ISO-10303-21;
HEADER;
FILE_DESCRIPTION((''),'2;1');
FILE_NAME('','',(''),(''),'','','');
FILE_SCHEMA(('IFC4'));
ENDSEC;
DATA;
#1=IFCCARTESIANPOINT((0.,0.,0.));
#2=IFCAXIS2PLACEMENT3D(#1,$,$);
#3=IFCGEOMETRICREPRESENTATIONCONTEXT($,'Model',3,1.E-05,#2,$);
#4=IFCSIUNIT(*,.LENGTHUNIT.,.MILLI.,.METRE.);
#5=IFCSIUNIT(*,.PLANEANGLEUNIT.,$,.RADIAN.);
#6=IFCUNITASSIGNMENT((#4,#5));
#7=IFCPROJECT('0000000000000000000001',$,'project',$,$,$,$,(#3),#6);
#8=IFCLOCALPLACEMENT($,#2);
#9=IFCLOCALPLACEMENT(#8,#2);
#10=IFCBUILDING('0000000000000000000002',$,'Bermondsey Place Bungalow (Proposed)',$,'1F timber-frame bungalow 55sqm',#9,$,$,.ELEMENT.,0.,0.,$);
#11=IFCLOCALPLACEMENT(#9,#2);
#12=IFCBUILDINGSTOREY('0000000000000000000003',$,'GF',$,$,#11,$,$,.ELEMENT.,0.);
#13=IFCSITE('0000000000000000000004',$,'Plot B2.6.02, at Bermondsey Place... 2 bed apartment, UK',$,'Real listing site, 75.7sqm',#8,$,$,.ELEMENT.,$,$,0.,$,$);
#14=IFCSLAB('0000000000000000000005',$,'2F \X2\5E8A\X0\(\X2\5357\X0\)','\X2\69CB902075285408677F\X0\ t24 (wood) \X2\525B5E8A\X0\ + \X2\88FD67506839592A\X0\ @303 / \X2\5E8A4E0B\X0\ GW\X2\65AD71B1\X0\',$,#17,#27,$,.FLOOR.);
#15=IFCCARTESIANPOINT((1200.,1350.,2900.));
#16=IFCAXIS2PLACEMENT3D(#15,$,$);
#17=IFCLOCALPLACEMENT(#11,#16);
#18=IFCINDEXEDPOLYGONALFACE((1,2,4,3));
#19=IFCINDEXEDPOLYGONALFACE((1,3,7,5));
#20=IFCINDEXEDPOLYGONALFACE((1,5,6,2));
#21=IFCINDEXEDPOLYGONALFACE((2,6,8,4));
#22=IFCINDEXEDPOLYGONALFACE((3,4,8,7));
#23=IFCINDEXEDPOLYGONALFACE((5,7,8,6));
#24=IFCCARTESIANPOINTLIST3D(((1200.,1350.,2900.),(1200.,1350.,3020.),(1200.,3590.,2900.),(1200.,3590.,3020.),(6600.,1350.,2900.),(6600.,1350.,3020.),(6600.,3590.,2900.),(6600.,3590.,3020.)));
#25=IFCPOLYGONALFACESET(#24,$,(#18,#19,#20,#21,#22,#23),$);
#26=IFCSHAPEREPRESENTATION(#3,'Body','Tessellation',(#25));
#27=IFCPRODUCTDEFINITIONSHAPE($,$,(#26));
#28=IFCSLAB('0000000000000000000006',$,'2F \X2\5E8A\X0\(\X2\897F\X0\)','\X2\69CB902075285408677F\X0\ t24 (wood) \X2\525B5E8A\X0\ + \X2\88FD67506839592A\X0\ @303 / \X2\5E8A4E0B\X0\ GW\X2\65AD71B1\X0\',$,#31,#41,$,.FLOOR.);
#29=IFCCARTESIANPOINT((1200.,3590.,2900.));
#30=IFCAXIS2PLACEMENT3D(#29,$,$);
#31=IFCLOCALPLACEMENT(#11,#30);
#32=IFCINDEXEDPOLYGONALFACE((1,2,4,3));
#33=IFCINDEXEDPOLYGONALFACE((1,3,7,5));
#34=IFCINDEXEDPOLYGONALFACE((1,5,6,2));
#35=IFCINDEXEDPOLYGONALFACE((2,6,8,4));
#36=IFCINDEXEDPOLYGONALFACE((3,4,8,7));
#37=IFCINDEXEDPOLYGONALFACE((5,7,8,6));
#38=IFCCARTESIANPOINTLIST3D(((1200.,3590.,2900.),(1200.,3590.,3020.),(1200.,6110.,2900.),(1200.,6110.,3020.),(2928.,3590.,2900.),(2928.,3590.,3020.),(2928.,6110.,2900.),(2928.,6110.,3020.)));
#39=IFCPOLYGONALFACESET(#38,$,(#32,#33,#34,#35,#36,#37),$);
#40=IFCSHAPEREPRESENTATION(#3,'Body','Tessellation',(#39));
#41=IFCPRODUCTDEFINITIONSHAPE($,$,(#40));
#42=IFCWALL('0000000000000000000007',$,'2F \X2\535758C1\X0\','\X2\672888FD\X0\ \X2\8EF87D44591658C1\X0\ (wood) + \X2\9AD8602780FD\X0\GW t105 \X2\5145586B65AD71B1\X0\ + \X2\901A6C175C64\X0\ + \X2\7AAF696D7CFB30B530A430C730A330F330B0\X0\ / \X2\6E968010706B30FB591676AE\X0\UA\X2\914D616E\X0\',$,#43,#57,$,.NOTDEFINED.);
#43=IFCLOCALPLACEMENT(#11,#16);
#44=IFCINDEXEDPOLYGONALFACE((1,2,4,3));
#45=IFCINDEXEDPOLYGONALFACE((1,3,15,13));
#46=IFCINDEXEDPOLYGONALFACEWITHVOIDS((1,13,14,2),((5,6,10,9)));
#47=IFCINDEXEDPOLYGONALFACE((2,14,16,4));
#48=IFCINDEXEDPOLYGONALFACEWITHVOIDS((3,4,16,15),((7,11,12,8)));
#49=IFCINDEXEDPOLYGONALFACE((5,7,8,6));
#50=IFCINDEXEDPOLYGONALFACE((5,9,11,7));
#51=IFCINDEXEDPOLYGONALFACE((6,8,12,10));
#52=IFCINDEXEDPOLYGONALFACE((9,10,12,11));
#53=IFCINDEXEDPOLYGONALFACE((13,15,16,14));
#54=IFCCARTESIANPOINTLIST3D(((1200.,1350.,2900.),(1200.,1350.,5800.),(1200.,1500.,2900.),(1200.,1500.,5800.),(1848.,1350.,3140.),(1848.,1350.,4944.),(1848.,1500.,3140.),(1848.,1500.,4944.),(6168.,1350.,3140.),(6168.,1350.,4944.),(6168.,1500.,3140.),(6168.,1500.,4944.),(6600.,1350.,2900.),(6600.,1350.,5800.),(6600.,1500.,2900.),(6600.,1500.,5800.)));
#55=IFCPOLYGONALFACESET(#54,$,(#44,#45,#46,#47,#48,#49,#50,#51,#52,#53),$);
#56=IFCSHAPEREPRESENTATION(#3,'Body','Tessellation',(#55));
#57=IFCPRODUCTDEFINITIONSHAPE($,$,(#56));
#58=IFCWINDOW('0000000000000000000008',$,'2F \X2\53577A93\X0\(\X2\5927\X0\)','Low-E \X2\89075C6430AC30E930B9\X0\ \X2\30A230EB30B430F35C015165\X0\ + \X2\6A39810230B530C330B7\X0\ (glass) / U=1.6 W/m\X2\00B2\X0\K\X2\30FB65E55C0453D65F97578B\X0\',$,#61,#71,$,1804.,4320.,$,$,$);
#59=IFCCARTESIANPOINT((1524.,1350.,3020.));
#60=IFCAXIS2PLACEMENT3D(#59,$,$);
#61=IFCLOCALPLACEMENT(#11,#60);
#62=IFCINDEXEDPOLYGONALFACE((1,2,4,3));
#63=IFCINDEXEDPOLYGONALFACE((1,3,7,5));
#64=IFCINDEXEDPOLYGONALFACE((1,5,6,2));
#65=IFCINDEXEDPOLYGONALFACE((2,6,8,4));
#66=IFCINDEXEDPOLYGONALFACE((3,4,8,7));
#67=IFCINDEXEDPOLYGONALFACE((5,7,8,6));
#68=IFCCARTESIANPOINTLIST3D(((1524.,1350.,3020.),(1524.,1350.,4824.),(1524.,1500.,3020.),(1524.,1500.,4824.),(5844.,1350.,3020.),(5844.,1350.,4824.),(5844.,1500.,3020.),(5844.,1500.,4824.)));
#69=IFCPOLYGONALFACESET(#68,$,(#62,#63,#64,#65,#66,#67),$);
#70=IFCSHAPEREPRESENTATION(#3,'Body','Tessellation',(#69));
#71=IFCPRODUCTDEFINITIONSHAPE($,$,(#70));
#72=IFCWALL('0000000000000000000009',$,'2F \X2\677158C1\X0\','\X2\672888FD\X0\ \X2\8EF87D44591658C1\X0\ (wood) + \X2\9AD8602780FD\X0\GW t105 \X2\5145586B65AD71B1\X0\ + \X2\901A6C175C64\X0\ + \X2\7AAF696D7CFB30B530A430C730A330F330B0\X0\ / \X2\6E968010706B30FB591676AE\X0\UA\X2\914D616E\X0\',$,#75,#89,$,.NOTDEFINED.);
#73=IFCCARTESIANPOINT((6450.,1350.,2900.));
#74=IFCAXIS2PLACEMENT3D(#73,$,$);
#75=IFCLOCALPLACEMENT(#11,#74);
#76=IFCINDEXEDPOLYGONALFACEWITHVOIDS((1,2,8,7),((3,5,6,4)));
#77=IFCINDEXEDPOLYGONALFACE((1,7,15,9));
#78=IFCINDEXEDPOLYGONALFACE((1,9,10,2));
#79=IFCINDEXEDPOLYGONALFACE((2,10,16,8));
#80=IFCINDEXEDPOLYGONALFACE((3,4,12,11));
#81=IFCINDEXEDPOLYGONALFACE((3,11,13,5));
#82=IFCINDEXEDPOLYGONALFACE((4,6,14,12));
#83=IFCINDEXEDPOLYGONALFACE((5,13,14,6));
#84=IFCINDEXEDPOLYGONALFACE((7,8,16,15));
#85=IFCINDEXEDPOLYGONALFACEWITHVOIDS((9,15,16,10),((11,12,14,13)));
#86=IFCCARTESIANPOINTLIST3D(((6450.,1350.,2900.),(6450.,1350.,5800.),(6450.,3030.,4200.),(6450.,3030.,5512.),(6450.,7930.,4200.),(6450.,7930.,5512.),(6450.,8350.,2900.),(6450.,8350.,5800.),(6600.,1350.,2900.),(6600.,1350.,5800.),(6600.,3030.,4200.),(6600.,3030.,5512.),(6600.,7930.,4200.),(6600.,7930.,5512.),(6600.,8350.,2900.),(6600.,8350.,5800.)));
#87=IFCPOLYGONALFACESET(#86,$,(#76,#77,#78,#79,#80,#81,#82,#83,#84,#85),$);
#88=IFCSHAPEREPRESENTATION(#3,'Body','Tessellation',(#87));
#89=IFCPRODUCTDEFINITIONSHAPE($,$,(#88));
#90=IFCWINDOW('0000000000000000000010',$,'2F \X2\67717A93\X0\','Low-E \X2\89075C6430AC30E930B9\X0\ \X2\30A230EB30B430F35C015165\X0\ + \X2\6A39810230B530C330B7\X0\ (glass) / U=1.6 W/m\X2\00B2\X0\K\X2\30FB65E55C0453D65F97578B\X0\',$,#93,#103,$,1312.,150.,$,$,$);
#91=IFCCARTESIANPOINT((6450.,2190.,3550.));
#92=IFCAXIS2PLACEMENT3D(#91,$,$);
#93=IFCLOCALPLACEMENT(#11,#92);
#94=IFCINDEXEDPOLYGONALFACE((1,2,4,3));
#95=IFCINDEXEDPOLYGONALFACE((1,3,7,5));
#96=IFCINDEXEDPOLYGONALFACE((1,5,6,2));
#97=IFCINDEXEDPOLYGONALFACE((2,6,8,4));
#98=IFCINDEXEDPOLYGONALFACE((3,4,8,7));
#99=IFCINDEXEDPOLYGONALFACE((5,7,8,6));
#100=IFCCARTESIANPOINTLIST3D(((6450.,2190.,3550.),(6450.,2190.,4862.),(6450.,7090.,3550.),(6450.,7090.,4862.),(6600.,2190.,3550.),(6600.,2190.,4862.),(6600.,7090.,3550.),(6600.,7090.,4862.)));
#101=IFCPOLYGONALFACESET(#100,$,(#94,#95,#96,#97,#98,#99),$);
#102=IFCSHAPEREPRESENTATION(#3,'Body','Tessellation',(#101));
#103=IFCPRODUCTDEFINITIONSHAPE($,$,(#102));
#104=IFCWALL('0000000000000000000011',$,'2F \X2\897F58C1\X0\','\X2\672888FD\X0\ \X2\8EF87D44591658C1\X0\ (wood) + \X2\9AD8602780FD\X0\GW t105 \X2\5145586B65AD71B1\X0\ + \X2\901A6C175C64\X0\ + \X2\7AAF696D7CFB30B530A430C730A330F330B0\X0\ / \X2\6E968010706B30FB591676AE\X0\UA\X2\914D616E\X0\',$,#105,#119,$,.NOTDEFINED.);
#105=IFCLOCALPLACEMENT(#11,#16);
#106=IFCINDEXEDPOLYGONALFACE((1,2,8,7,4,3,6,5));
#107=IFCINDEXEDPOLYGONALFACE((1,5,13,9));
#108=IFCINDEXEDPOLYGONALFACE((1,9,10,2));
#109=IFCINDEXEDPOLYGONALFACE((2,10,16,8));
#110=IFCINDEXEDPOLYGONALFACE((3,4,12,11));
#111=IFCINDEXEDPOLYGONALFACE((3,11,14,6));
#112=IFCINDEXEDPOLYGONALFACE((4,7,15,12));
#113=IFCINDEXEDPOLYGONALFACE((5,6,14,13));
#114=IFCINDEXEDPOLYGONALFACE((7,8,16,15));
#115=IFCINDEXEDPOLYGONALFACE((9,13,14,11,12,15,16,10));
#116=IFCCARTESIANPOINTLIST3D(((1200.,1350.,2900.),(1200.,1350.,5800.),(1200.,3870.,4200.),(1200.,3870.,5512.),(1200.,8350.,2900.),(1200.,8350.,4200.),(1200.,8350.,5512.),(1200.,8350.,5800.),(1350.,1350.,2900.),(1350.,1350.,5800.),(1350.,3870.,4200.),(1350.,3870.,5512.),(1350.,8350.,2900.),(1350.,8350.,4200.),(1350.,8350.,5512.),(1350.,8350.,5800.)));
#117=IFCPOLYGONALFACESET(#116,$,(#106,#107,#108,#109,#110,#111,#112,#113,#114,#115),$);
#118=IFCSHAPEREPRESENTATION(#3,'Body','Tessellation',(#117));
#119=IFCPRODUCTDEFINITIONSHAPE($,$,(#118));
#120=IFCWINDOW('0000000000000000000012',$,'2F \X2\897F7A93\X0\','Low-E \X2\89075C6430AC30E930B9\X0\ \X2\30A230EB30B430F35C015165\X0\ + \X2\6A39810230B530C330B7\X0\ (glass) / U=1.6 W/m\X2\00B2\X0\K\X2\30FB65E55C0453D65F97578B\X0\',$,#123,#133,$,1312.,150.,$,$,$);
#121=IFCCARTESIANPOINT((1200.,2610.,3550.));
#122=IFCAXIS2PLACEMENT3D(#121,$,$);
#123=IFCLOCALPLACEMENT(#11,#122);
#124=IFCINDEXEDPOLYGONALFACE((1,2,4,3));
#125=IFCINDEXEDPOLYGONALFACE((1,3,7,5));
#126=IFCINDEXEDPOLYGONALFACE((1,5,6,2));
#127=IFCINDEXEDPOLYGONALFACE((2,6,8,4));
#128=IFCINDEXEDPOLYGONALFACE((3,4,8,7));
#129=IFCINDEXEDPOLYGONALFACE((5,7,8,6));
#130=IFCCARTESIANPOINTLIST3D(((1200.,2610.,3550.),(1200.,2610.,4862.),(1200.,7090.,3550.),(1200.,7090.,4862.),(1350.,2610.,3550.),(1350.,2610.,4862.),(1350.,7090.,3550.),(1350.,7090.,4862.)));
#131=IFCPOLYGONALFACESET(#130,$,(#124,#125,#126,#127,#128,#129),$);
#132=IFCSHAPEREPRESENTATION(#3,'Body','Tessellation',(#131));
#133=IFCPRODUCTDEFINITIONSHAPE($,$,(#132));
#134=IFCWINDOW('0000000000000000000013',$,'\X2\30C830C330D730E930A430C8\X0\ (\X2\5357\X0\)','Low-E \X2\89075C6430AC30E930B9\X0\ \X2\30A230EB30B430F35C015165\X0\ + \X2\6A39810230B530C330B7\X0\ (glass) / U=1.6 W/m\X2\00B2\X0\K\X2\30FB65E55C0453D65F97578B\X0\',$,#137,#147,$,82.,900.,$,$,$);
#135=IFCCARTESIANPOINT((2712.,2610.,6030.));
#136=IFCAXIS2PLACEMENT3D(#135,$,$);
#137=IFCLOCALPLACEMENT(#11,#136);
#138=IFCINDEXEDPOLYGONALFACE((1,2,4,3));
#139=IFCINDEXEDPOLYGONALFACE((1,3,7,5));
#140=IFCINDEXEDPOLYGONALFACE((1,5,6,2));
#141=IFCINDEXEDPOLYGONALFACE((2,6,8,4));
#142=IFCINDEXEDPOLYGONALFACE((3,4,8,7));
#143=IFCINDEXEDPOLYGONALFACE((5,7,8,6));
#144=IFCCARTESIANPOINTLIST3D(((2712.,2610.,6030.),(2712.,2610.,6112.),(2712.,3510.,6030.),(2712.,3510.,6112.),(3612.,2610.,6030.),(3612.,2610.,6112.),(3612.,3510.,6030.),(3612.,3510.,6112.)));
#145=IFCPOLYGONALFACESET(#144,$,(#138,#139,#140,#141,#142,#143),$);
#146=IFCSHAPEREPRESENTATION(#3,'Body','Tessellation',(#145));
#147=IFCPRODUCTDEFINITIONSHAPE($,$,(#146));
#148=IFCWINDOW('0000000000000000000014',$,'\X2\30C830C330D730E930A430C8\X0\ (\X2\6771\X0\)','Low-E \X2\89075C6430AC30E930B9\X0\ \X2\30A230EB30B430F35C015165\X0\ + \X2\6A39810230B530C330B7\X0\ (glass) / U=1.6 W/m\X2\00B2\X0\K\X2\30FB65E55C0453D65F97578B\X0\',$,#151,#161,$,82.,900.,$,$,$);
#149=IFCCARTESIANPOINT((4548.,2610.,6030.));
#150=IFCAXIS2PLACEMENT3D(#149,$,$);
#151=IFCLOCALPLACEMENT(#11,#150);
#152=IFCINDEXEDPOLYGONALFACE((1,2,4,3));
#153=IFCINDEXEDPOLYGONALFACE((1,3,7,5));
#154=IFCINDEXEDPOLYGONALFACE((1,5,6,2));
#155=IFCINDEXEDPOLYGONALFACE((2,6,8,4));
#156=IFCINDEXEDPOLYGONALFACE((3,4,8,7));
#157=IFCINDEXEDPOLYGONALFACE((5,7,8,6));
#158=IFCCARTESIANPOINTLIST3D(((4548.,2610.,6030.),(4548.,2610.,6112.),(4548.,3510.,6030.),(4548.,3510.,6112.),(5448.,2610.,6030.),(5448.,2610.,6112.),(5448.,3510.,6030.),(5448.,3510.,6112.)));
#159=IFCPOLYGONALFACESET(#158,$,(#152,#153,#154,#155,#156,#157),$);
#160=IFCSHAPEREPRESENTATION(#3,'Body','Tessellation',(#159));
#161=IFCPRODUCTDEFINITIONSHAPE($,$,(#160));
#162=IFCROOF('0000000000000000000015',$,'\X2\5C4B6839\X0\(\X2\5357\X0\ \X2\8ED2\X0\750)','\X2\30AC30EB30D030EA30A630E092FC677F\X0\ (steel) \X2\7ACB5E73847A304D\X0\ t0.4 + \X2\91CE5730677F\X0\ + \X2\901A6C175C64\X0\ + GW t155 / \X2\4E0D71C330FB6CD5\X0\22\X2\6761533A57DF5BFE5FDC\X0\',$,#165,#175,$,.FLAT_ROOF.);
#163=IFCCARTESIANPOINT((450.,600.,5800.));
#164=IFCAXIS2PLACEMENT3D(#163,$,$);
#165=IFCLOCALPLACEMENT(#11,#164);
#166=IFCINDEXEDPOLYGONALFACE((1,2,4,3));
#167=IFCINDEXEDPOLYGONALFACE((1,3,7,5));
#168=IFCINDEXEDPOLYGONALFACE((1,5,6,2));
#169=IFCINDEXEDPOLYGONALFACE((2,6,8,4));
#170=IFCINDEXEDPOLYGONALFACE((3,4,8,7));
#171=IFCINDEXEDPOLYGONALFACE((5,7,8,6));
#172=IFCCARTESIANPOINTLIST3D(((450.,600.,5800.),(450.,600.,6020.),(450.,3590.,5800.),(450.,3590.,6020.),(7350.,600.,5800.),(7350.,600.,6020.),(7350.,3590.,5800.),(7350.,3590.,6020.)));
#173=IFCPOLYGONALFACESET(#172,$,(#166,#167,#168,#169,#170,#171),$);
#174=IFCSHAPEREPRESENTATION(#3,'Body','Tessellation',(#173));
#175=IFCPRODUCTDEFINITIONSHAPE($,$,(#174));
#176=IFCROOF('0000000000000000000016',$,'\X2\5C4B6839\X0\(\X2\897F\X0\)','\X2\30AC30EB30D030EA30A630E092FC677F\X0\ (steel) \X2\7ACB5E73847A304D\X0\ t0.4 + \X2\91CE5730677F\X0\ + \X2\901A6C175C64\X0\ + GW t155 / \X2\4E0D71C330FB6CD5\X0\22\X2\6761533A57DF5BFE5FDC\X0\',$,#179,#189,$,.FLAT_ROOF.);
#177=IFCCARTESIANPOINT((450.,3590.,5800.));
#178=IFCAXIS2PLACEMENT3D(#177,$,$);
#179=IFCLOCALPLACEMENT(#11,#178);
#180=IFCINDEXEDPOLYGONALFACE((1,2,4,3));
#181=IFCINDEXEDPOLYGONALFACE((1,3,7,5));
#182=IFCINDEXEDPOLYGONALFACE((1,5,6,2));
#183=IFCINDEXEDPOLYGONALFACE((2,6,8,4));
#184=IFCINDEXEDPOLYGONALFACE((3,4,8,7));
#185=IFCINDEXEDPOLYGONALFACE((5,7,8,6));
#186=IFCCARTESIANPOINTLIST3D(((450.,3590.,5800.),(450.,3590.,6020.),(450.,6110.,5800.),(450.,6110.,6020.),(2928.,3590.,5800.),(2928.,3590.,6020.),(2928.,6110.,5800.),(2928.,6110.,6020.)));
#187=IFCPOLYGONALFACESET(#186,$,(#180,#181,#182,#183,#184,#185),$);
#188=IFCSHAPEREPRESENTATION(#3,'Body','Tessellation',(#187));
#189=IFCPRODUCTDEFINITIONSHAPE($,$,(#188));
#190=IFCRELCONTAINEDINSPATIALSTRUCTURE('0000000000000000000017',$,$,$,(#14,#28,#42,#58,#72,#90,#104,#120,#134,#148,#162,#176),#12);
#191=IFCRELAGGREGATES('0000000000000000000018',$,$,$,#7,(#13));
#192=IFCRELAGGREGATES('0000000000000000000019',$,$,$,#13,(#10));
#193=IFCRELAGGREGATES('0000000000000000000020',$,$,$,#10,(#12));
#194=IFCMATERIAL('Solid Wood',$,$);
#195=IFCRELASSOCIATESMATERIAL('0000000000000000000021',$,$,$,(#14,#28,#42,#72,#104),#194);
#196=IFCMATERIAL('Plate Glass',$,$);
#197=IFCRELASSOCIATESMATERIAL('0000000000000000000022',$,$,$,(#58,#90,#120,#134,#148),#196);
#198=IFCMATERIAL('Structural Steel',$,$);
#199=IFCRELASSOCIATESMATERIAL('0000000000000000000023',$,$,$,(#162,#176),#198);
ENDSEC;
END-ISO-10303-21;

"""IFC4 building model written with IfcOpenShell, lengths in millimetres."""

from ifc_helpers import new_model, si_unit, frame, frame_2d, origin, place, context, project, spatial, rectangle, extrude, material, element, fill, save


model = new_model("IFC4")

# Units and contexts
model_context = context("Model", 3, precision=1e-05, world=origin())
ifc_project = project(units=[si_unit("LENGTHUNIT", "METRE", prefix="MILLI"), si_unit("PLANEANGLEUNIT", "RADIAN")], contexts=[model_context])

# Site, building, storey
site_placement = place(None, origin())
site = spatial("IfcSite", under=ifc_project, at=site_placement, Name="Plot B2.6.02, at Bermondsey Place... 2 bed apartment, UK", ObjectType="Real listing site, 75.7sqm", CompositionType="ELEMENT", RefElevation=0.0)
building_placement = place(site_placement, origin())
building = spatial("IfcBuilding", under=site, at=building_placement, Name="Bermondsey Place Bungalow (Proposed)", ObjectType="1F timber-frame bungalow 55sqm", CompositionType="ELEMENT", ElevationOfRefHeight=0.0, ElevationOfTerrain=0.0)
storey_placement = place(building_placement, origin())
storey = spatial("IfcBuildingStorey", under=building, at=storey_placement, Name="GF", CompositionType="ELEMENT", Elevation=0.0)

# Slabs
ifc_material_1 = material(Name="Solid Wood")
slab_1_placement = place(storey_placement, frame((1200.0, 1350.0, 2900.0)))
element("IfcSlab", 1, at=slab_1_placement, inside=storey, material=ifc_material_1, Name="2F 床(南)", Description="構造用合板 t24 (wood) 剛床 + 製材根太 @303 / 床下 GW断熱", PredefinedType="FLOOR", context=model_context, shape_type="SweptSolid", body=[
    extrude(rectangle(XDim=5400.0, YDim=2240.0, at=frame_2d((2700.0, 1120.0))), frame((1200.0, 1350.0, 2900.0)), (0.0, 0.0, 1.0), 120.0),
])
slab_2_placement = place(storey_placement, frame((1200.0, 3590.0, 2900.0)))
element("IfcSlab", 2, at=slab_2_placement, inside=storey, material=ifc_material_1, Name="2F 床(西)", Description="構造用合板 t24 (wood) 剛床 + 製材根太 @303 / 床下 GW断熱", PredefinedType="FLOOR", context=model_context, shape_type="SweptSolid", body=[
    extrude(rectangle(XDim=1728.0, YDim=2520.0, at=frame_2d((864.0, 1260.0))), frame((1200.0, 3590.0, 2900.0)), (0.0, 0.0, 1.0), 120.0),
])

# Walls, openings, windows
wall_1_placement = place(storey_placement, frame((1200.0, 1350.0, 2900.0)))
wall_1 = element("IfcWall", 3, at=wall_1_placement, inside=storey, material=ifc_material_1, Name="2F 南壁", Description="木製 軸組外壁 (wood) + 高性能GW t105 充填断熱 + 通気層 + 窯業系サイディング / 準耐火・外皮UA配慮", PredefinedType="NOTDEFINED", context=model_context, shape_type="SweptSolid", body=[
    extrude(rectangle(XDim=5400.0, YDim=150.0, at=frame_2d((2700.0, 75.0))), frame((1200.0, 1350.0, 2900.0)), (0.0, 0.0, 1.0), 2900.0),
])
opening_1_placement = place(storey_placement, frame((1524.0, 1350.0, 3020.0)))
opening_1 = element("IfcOpeningElement", 4, at=opening_1_placement, cuts=wall_1, PredefinedType="NOTDEFINED", context=model_context, shape_type="SweptSolid", body=[
    extrude(rectangle(XDim=4320.0, YDim=150.0, at=frame_2d((2160.0, 75.0))), frame((1524.0, 1350.0, 3020.0)), (0.0, 0.0, 1.0), 1804.0),
])
ifc_material_2 = material(Name="Plate Glass")
window_1_placement = place(storey_placement, frame((1524.0, 1350.0, 3020.0)))
window_1 = element("IfcWindow", 5, at=window_1_placement, inside=storey, material=ifc_material_2, Name="2F 南窓(大)", Description="Low-E 複層ガラス アルゴン封入 + 樹脂サッシ (glass) / U=1.6 W/m²K・日射取得型", OverallHeight=1804.0, OverallWidth=4320.0, context=model_context, shape_type="SweptSolid", body=[
    extrude(rectangle(XDim=4320.0, YDim=150.0, at=frame_2d((2160.0, 75.0))), frame((1524.0, 1350.0, 3020.0)), (0.0, 0.0, 1.0), 1804.0),
])
fill(opening_1, window_1)
wall_2_placement = place(storey_placement, frame((6450.0, 1350.0, 2900.0)))
wall_2 = element("IfcWall", 6, at=wall_2_placement, inside=storey, material=ifc_material_1, Name="2F 東壁", Description="木製 軸組外壁 (wood) + 高性能GW t105 充填断熱 + 通気層 + 窯業系サイディング / 準耐火・外皮UA配慮", PredefinedType="NOTDEFINED", context=model_context, shape_type="SweptSolid", body=[
    extrude(rectangle(XDim=150.0, YDim=7000.0, at=frame_2d((75.0, 3500.0))), frame((6450.0, 1350.0, 2900.0)), (0.0, 0.0, 1.0), 2900.0),
])
opening_2_placement = place(storey_placement, frame((6450.0, 2190.0, 3550.0)))
opening_2 = element("IfcOpeningElement", 7, at=opening_2_placement, cuts=wall_2, PredefinedType="NOTDEFINED", context=model_context, shape_type="SweptSolid", body=[
    extrude(rectangle(XDim=150.0, YDim=4900.0, at=frame_2d((75.0, 2450.0))), frame((6450.0, 2190.0, 3550.0)), (0.0, 0.0, 1.0), 1312.0),
])
window_2_placement = place(storey_placement, frame((6450.0, 2190.0, 3550.0)))
window_2 = element("IfcWindow", 8, at=window_2_placement, inside=storey, material=ifc_material_2, Name="2F 東窓", Description="Low-E 複層ガラス アルゴン封入 + 樹脂サッシ (glass) / U=1.6 W/m²K・日射取得型", OverallHeight=1312.0, OverallWidth=150.0, context=model_context, shape_type="SweptSolid", body=[
    extrude(rectangle(XDim=150.0, YDim=4900.0, at=frame_2d((75.0, 2450.0))), frame((6450.0, 2190.0, 3550.0)), (0.0, 0.0, 1.0), 1312.0),
])
fill(opening_2, window_2)
wall_3_placement = place(storey_placement, frame((1200.0, 1350.0, 2900.0)))
wall_3 = element("IfcWall", 9, at=wall_3_placement, inside=storey, material=ifc_material_1, Name="2F 西壁", Description="木製 軸組外壁 (wood) + 高性能GW t105 充填断熱 + 通気層 + 窯業系サイディング / 準耐火・外皮UA配慮", PredefinedType="NOTDEFINED", context=model_context, shape_type="SweptSolid", body=[
    extrude(rectangle(XDim=150.0, YDim=7000.0, at=frame_2d((75.0, 3500.0))), frame((1200.0, 1350.0, 2900.0)), (0.0, 0.0, 1.0), 2900.0),
])
opening_3_placement = place(storey_placement, frame((1200.0, 2610.0, 3550.0)))
opening_3 = element("IfcOpeningElement", 10, at=opening_3_placement, cuts=wall_3, PredefinedType="NOTDEFINED", context=model_context, shape_type="SweptSolid", body=[
    extrude(rectangle(XDim=150.0, YDim=4480.0, at=frame_2d((75.0, 2240.0))), frame((1200.0, 2610.0, 3550.0)), (0.0, 0.0, 1.0), 1312.0),
])
window_3_placement = place(storey_placement, frame((1200.0, 2610.0, 3550.0)))
window_3 = element("IfcWindow", 11, at=window_3_placement, inside=storey, material=ifc_material_2, Name="2F 西窓", Description="Low-E 複層ガラス アルゴン封入 + 樹脂サッシ (glass) / U=1.6 W/m²K・日射取得型", OverallHeight=1312.0, OverallWidth=150.0, context=model_context, shape_type="SweptSolid", body=[
    extrude(rectangle(XDim=150.0, YDim=4480.0, at=frame_2d((75.0, 2240.0))), frame((1200.0, 2610.0, 3550.0)), (0.0, 0.0, 1.0), 1312.0),
])
fill(opening_3, window_3)

# Windows
window_4_placement = place(storey_placement, frame((2712.0, 2610.0, 6030.0)))
element("IfcWindow", 12, at=window_4_placement, inside=storey, material=ifc_material_2, Name="トップライト (南)", Description="Low-E 複層ガラス アルゴン封入 + 樹脂サッシ (glass) / U=1.6 W/m²K・日射取得型", OverallHeight=82.0, OverallWidth=900.0, context=model_context, shape_type="SweptSolid", body=[
    extrude(rectangle(XDim=900.0, YDim=900.0, at=frame_2d((450.0, 450.0))), frame((2712.0, 2610.0, 6030.0)), (0.0, 0.0, 1.0), 82.0),
])
window_5_placement = place(storey_placement, frame((4548.0, 2610.0, 6030.0)))
element("IfcWindow", 13, at=window_5_placement, inside=storey, material=ifc_material_2, Name="トップライト (東)", Description="Low-E 複層ガラス アルゴン封入 + 樹脂サッシ (glass) / U=1.6 W/m²K・日射取得型", OverallHeight=82.0, OverallWidth=900.0, context=model_context, shape_type="SweptSolid", body=[
    extrude(rectangle(XDim=900.0, YDim=900.0, at=frame_2d((450.0, 450.0))), frame((4548.0, 2610.0, 6030.0)), (0.0, 0.0, 1.0), 82.0),
])

# Roofs
ifc_material_3 = material(Name="Structural Steel")
roof_1_placement = place(storey_placement, frame((450.0, 600.0, 5800.0)))
element("IfcRoof", 14, at=roof_1_placement, inside=storey, material=ifc_material_3, Name="屋根(南 軒750)", Description="ガルバリウム鋼板 (steel) 立平葺き t0.4 + 野地板 + 通気層 + GW t155 / 不燃・法22条区域対応", PredefinedType="FLAT_ROOF", context=model_context, shape_type="SweptSolid", body=[
    extrude(rectangle(XDim=6900.0, YDim=2990.0, at=frame_2d((3450.0, 1495.0))), frame((450.0, 600.0, 5800.0)), (0.0, 0.0, 1.0), 220.0),
])
roof_2_placement = place(storey_placement, frame((450.0, 3590.0, 5800.0)))
element("IfcRoof", 15, at=roof_2_placement, inside=storey, material=ifc_material_3, Name="屋根(西)", Description="ガルバリウム鋼板 (steel) 立平葺き t0.4 + 野地板 + 通気層 + GW t155 / 不燃・法22条区域対応", PredefinedType="FLAT_ROOF", context=model_context, shape_type="SweptSolid", body=[
    extrude(rectangle(XDim=2478.0, YDim=2520.0, at=frame_2d((1239.0, 1260.0))), frame((450.0, 3590.0, 5800.0)), (0.0, 0.0, 1.0), 220.0),
])

save(model, "model.ifc")
